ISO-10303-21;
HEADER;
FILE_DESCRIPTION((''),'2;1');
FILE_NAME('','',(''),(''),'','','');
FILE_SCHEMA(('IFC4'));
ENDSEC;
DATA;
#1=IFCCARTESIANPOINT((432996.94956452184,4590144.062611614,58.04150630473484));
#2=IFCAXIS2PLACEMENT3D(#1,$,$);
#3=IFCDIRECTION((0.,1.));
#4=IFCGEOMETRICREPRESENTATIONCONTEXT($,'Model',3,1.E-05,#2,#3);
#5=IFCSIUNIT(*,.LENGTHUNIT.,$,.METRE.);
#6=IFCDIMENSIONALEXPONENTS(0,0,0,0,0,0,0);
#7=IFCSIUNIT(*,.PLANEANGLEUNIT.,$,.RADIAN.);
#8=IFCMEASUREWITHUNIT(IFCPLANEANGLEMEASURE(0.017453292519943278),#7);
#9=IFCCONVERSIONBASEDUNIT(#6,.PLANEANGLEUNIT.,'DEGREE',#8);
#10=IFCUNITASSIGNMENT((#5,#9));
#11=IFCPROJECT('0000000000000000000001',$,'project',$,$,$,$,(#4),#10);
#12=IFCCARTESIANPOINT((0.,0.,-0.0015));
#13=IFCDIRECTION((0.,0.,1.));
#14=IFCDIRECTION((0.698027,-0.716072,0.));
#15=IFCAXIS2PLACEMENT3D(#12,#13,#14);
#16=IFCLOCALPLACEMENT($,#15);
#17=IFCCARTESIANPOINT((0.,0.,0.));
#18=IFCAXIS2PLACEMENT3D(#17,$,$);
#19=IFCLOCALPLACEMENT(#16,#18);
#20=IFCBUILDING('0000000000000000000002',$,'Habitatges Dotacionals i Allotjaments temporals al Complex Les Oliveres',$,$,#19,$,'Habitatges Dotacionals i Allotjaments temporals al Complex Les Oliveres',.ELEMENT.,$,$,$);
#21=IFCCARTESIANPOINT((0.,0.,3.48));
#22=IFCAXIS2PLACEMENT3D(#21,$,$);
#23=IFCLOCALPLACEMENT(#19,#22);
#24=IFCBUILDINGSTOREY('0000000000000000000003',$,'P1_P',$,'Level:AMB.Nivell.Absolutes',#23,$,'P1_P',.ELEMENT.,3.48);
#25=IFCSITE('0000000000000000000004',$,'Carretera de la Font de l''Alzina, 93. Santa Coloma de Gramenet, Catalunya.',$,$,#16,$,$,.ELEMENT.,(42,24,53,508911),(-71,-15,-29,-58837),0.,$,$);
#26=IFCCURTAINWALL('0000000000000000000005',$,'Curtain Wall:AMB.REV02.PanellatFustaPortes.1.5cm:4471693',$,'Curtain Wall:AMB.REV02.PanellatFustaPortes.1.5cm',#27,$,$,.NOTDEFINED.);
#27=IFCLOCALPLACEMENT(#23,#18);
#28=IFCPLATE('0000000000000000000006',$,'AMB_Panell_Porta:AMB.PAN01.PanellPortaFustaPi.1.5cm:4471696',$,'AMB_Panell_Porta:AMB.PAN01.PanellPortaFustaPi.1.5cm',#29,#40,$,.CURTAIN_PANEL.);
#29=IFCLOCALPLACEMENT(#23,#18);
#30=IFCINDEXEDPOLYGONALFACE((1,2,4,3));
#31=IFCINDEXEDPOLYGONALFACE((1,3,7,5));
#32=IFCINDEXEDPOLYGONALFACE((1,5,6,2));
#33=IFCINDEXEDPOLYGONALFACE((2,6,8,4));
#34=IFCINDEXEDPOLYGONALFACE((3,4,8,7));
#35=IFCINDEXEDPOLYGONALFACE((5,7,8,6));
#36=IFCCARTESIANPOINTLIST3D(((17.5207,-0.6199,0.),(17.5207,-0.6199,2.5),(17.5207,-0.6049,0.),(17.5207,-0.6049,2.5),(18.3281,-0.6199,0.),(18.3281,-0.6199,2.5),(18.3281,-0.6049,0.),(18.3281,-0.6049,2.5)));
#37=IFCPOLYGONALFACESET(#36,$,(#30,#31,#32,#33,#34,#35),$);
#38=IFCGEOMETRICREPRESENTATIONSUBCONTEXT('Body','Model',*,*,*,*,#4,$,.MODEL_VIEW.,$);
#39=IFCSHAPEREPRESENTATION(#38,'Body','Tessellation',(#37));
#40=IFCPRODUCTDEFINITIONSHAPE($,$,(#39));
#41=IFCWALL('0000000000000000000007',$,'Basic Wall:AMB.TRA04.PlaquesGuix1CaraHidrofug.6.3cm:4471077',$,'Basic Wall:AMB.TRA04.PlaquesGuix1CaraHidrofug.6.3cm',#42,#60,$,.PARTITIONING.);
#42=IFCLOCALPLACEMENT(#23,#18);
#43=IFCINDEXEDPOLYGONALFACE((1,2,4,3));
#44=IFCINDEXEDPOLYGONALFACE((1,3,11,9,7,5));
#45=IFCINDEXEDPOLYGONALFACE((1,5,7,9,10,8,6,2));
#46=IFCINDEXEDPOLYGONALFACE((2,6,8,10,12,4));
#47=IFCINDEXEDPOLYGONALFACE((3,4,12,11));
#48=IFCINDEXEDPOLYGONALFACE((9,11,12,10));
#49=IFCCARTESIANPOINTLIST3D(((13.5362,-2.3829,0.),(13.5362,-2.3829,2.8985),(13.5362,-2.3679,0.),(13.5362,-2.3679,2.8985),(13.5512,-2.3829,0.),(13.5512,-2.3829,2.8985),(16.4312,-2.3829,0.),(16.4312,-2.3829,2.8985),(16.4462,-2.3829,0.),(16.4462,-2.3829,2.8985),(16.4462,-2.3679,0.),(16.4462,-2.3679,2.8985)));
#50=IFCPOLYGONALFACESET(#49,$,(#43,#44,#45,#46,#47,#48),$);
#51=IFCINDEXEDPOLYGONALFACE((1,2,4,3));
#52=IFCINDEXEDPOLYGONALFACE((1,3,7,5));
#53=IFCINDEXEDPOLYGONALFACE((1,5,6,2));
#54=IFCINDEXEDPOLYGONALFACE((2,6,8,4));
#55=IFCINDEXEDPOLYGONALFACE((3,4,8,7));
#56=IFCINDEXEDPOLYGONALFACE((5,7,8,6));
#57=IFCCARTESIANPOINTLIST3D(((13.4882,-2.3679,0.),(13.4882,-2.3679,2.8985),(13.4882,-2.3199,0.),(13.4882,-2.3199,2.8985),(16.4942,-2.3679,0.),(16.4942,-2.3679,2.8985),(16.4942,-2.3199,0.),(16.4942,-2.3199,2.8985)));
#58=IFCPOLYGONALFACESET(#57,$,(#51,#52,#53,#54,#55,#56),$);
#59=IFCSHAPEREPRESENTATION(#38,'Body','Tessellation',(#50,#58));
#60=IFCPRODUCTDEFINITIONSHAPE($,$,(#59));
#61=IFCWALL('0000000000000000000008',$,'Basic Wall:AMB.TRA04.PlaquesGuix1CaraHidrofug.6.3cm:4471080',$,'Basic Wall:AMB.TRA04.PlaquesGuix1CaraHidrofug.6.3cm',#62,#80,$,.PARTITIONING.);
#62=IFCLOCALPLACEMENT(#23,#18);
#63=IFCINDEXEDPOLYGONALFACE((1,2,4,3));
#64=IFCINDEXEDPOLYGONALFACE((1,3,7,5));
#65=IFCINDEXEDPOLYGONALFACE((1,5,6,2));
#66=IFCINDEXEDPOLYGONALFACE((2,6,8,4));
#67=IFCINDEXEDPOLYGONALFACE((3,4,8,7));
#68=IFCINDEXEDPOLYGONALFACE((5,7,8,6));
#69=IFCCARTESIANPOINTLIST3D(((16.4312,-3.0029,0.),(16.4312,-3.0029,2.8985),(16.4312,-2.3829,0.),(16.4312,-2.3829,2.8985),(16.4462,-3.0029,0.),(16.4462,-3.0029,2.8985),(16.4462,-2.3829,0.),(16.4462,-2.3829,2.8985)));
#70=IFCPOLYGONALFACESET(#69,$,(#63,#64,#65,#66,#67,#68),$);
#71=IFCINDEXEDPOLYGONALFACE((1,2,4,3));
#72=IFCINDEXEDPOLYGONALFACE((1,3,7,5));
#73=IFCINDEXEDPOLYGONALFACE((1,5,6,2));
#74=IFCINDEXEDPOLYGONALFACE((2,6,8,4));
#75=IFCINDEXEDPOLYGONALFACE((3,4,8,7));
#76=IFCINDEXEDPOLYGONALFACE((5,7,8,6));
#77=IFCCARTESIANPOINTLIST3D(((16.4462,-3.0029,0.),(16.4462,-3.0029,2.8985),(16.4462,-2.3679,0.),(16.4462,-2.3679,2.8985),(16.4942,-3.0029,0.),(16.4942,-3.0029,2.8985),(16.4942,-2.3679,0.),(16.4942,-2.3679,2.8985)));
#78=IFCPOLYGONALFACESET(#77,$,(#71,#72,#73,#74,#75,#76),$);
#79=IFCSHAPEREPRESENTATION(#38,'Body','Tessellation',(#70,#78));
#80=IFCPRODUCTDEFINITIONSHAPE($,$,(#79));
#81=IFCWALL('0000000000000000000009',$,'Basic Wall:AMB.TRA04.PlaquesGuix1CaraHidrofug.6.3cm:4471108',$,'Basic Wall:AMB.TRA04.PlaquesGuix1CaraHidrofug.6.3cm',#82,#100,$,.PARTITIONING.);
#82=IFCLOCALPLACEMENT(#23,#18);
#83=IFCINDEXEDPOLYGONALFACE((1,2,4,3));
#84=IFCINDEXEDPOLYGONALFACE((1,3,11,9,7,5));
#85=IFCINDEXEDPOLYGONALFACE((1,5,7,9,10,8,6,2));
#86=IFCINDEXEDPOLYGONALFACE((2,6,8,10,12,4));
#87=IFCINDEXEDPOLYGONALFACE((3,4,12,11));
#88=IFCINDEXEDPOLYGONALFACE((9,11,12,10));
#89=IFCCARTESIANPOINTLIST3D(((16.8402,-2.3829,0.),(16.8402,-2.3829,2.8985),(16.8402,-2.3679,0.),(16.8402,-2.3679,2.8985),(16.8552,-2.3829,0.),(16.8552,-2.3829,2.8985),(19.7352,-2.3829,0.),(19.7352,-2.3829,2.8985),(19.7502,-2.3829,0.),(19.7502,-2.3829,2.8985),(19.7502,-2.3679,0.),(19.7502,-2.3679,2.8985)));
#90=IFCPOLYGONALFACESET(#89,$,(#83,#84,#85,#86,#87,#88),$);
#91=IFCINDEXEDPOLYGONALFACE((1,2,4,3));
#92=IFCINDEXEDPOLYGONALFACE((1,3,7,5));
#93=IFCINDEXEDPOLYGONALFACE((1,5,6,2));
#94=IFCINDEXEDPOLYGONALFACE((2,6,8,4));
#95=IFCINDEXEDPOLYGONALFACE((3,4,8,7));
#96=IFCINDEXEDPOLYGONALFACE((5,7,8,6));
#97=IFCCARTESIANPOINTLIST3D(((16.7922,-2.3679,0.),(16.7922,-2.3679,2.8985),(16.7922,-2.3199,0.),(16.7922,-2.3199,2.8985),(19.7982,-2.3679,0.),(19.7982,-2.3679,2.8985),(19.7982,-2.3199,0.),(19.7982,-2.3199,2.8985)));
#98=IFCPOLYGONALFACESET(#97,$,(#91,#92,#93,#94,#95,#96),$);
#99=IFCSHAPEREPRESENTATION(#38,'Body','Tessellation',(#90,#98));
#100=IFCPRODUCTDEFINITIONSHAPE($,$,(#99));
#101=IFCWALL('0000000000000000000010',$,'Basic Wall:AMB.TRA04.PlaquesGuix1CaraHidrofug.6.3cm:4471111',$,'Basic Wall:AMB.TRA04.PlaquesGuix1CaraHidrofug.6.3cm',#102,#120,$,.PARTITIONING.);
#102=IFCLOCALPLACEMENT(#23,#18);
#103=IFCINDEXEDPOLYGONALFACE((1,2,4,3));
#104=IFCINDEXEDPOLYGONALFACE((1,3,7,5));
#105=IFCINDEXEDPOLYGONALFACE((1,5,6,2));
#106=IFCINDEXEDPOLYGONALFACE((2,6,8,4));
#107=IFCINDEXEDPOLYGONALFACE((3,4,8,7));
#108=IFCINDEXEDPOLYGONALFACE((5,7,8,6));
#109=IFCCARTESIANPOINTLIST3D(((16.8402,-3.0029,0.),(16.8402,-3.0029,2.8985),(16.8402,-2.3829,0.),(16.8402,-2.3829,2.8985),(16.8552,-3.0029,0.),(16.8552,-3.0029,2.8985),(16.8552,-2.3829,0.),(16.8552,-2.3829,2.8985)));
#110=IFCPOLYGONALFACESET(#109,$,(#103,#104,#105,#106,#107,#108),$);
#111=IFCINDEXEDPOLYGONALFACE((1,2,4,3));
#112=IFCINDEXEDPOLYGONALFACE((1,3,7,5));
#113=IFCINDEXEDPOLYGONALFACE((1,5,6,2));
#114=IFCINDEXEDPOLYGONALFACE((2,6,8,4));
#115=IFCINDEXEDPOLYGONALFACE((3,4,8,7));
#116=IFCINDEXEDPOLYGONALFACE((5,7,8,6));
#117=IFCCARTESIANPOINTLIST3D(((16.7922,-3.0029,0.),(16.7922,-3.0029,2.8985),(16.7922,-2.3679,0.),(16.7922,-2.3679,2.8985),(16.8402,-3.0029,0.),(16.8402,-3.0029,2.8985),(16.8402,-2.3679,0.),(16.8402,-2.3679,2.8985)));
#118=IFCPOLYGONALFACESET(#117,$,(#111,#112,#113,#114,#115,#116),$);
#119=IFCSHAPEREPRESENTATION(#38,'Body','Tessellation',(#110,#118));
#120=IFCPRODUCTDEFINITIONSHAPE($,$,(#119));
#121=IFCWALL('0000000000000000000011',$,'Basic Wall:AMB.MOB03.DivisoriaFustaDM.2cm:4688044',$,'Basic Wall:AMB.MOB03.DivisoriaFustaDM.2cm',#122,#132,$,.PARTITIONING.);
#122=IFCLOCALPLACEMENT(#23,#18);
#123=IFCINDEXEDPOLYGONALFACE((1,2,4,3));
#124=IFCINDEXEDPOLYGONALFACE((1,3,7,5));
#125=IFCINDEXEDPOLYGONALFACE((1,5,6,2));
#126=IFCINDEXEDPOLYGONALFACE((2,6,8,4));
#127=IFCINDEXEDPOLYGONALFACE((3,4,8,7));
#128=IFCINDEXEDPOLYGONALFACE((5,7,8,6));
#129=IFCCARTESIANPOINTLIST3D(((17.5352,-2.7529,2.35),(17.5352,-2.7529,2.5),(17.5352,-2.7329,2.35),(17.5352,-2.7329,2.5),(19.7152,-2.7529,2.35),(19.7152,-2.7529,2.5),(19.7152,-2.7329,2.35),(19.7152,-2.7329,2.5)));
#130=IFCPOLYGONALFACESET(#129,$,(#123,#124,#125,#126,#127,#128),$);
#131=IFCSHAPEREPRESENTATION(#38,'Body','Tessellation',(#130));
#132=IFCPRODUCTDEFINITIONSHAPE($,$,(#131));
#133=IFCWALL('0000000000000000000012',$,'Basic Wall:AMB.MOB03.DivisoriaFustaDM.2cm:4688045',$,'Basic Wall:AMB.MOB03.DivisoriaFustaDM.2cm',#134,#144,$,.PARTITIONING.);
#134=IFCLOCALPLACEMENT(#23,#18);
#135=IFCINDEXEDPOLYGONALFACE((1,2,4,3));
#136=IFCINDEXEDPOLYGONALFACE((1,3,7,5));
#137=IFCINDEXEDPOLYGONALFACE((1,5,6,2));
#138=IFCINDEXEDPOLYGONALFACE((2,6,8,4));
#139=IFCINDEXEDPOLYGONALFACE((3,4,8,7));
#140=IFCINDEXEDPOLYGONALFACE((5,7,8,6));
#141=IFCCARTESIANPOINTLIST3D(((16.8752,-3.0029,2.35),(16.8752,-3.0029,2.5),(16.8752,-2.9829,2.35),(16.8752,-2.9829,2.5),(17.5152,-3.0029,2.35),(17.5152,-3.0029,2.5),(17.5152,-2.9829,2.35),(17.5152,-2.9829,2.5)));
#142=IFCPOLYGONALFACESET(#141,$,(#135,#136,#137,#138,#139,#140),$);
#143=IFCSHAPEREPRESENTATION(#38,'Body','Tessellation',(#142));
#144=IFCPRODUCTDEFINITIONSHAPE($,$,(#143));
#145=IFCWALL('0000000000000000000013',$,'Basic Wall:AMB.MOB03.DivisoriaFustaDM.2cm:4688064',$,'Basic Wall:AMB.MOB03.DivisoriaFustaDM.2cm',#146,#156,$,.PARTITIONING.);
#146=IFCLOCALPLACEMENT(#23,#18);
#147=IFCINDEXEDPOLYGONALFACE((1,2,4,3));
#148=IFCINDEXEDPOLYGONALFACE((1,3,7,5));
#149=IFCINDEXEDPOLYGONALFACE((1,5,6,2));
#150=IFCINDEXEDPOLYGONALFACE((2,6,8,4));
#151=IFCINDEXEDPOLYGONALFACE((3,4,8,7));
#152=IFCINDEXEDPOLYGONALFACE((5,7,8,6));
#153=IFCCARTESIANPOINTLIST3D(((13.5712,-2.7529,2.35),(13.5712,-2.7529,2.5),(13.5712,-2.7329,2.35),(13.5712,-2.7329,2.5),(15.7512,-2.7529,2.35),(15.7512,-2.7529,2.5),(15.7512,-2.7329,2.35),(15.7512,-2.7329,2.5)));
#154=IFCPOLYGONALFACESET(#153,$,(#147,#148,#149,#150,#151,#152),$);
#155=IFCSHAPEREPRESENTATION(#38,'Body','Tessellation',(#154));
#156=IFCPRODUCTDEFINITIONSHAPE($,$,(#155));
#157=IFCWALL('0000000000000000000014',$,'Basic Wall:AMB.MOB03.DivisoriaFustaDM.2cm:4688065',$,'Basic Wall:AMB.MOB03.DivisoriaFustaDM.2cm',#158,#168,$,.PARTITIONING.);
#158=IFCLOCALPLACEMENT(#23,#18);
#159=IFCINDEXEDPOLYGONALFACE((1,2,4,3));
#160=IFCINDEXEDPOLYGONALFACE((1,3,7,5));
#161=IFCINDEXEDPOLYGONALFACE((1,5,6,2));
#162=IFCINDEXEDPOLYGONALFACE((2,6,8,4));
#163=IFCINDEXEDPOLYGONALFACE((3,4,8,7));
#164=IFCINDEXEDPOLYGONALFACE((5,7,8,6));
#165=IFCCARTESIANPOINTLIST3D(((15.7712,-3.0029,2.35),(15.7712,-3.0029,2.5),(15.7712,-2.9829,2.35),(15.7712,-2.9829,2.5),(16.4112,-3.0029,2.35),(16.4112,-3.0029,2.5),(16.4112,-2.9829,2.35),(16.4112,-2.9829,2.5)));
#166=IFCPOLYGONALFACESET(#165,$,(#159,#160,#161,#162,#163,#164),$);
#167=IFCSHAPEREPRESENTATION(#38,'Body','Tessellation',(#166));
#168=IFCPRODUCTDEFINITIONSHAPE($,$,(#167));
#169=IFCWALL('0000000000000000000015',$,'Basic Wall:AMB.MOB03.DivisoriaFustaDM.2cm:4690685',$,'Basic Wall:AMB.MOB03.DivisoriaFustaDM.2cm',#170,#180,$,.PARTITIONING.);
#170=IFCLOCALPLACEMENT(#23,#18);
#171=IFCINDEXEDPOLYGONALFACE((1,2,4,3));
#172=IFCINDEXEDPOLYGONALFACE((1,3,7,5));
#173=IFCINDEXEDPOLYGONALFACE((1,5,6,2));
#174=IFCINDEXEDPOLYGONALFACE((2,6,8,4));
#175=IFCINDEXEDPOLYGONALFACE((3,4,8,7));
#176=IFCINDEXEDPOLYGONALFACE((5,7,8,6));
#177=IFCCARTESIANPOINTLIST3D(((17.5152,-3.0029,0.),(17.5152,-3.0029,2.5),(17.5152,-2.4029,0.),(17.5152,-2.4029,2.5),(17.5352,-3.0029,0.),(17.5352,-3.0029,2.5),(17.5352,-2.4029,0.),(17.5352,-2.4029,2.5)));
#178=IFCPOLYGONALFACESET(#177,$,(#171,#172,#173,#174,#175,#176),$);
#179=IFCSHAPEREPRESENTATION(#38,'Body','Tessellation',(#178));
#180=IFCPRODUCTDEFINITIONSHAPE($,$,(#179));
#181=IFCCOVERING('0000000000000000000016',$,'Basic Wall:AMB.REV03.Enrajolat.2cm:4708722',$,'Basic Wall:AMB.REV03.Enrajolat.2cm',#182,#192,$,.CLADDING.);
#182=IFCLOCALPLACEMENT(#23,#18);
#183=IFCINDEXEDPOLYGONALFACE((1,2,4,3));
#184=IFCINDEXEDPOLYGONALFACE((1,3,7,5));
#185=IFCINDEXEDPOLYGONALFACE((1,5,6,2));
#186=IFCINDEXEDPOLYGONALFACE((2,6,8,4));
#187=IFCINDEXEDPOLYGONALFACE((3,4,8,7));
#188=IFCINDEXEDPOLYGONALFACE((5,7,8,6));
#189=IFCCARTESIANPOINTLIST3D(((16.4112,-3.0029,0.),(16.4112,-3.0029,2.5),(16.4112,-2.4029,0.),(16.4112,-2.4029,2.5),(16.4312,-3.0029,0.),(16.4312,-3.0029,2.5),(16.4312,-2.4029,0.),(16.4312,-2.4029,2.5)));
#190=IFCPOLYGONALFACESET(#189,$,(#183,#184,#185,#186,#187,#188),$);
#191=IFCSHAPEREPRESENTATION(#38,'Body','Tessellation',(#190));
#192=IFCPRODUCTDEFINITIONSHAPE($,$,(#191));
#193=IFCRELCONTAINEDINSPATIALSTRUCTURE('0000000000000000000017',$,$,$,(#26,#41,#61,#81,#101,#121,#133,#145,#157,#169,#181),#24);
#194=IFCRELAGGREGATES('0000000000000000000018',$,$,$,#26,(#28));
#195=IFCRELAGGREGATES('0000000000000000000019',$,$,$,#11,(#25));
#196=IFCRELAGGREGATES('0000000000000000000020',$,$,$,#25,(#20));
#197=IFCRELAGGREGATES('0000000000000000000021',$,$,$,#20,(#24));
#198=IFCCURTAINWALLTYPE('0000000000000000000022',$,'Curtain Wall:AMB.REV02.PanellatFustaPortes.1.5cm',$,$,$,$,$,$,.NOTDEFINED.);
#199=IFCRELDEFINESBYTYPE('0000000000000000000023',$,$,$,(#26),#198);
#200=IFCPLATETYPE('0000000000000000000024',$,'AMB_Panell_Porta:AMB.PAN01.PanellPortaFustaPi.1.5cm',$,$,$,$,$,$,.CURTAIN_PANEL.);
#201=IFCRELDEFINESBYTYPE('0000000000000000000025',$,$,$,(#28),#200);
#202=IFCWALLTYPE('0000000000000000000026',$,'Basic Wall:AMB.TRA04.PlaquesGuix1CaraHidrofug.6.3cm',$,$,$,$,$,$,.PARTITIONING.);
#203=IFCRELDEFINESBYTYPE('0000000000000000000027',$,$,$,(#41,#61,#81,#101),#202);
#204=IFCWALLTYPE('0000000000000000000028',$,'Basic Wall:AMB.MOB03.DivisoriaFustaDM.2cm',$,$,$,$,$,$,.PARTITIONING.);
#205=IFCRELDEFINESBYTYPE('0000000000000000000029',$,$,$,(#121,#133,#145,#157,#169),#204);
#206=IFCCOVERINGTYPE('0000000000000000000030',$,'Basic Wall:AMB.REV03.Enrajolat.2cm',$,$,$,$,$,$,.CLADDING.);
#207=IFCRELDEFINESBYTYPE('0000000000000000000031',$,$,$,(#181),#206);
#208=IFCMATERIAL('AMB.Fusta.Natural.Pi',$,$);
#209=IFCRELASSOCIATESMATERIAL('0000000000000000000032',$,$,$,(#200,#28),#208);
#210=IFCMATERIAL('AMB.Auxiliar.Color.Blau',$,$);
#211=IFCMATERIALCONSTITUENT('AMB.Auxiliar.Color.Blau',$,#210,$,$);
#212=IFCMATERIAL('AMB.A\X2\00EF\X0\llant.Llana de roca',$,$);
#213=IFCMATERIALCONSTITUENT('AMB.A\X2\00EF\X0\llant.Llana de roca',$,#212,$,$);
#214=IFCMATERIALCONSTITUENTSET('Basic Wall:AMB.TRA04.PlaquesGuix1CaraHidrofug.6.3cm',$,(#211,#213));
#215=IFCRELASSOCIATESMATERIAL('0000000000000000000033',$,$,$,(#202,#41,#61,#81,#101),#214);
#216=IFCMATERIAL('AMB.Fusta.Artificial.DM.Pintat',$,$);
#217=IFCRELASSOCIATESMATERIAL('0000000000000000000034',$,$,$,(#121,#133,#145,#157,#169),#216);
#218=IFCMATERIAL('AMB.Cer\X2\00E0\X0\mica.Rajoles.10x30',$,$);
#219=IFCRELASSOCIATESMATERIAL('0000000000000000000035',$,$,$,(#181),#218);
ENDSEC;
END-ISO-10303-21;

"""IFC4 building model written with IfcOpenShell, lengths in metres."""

from ifc_helpers import new_model, entity, si_unit, converted_unit, direction, frame, origin, place, context, subcontext, project, spatial, indexed_curve, outline, extrude, source, transform, mapped, material, constituent, constituent_set, type_object, type_shapes, element, aggregate, save


model = new_model("IFC4")

# Units and contexts
model_context = context("Model", 3, precision=1e-05, world=frame((432996.94956452184, 4590144.062611614, 58.04150630473484)), true_north=direction((0.0, 1.0)))
body_context = subcontext(model_context, "Body", "Model", "MODEL_VIEW")
ifc_project = project(units=[si_unit("LENGTHUNIT", "METRE"), converted_unit("PLANEANGLEUNIT", "DEGREE", entity("IfcPlaneAngleMeasure", 0.017453292519943278), si_unit("PLANEANGLEUNIT", "RADIAN"), dimensions=[0, 0, 0, 0, 0, 0, 0])], contexts=[model_context])

# Site, building, storey
site_placement = place(None, frame((0.0, 0.0, -0.0015), z_axis=(0.0, 0.0, 1.0), x_axis=(0.698027, -0.716072, 0.0)))
site = spatial("IfcSite", under=ifc_project, at=site_placement, Name="Carretera de la Font de l'Alzina, 93. Santa Coloma de Gramenet, Catalunya.", CompositionType="ELEMENT", RefLatitude=(42, 24, 53, 508911), RefLongitude=(-71, -15, -29, -58837), RefElevation=0.0)
building_placement = place(site_placement, origin())
building = spatial("IfcBuilding", under=site, at=building_placement, Name="Habitatges Dotacionals i Allotjaments temporals al Complex Les Oliveres", LongName="Habitatges Dotacionals i Allotjaments temporals al Complex Les Oliveres", CompositionType="ELEMENT")
storey_placement = place(building_placement, frame((0.0, 0.0, 3.48)))
storey = spatial("IfcBuildingStorey", under=building, at=storey_placement, Name="P1_P", ObjectType="Level:AMB.Nivell.Absolutes", LongName="P1_P", CompositionType="ELEMENT", Elevation=3.48)

# Curtain wall, plate
curtain_wall_type = type_object("IfcCurtainWallType", Name="Curtain Wall:AMB.REV02.PanellatFustaPortes.1.5cm", PredefinedType="NOTDEFINED")
curtain_wall_placement = place(storey_placement, frame((0.0, 0.0, -3.48)))
curtain_wall = element("IfcCurtainWall", 1, at=curtain_wall_placement, inside=storey, type_object=curtain_wall_type, Name="Curtain Wall:AMB.REV02.PanellatFustaPortes.1.5cm:4471693", ObjectType="Curtain Wall:AMB.REV02.PanellatFustaPortes.1.5cm", PredefinedType="NOTDEFINED")
ifc_material_1 = material(Name="AMB.Fusta.Natural.Pi")
plate_type = type_object("IfcPlateType", Name="AMB_Panell_Porta:AMB.PAN01.PanellPortaFustaPi.1.5cm", PredefinedType="CURTAIN_PANEL", material=ifc_material_1)
shared_shape_1 = source(origin(), body_context, "Body", "SweptSolid", [
    extrude(outline(indexed_curve([(-0.0075, -0.4037), (0.0075, -0.4037), (0.0075, 0.4037), (-0.0075, 0.4037), (-0.0075, -0.4037)], self_intersect=False)), frame((0.0, 0.0, 0.0), z_axis=(0.0, 0.0, 1.0), x_axis=(0.0, 1.0, 0.0)), (0.0, 0.0, 1.0), 2.5),
])
type_shapes(plate_type, [shared_shape_1])
plate_placement = place(curtain_wall_placement, frame((17.9244, -0.6124, 3.48)))
plate = element("IfcPlate", 2, at=plate_placement, type_object=plate_type, material=ifc_material_1, Name="AMB_Panell_Porta:AMB.PAN01.PanellPortaFustaPi.1.5cm:4471696", ObjectType="AMB_Panell_Porta:AMB.PAN01.PanellPortaFustaPi.1.5cm", PredefinedType="CURTAIN_PANEL", context=body_context, shape_type="MappedRepresentation", body=[
    mapped(shared_shape_1, transform((0.0, 0.0, 0.0), scale=1.0)),
])
aggregate(curtain_wall, [plate])

# Walls
ifc_material_2 = material(Name="AMB.Auxiliar.Color.Blau")
ifc_constituent_1 = constituent(ifc_material_2, Name="AMB.Auxiliar.Color.Blau")
ifc_material_3 = material(Name="AMB.Aïllant.Llana de roca")
ifc_constituent_2 = constituent(ifc_material_3, Name="AMB.Aïllant.Llana de roca")
ifc_constituent_set = constituent_set(constituents=[ifc_constituent_1, ifc_constituent_2], Name="Basic Wall:AMB.TRA04.PlaquesGuix1CaraHidrofug.6.3cm")
wall_type_1 = type_object("IfcWallType", Name="Basic Wall:AMB.TRA04.PlaquesGuix1CaraHidrofug.6.3cm", PredefinedType="PARTITIONING", material=ifc_constituent_set)
wall_1_placement = place(storey_placement, frame((16.4942, -2.3514, 0.0), z_axis=(0.0, 0.0, 1.0), x_axis=(-1.0, 0.0, 0.0)))
element("IfcWall", 3, at=wall_1_placement, inside=storey, type_object=wall_type_1, material=ifc_constituent_set, Name="Basic Wall:AMB.TRA04.PlaquesGuix1CaraHidrofug.6.3cm:4471077", ObjectType="Basic Wall:AMB.TRA04.PlaquesGuix1CaraHidrofug.6.3cm", PredefinedType="PARTITIONING", context=body_context, shape_type="SweptSolid", body=[
    extrude(outline(indexed_curve([(-1.44, -0.005), (1.44, -0.005), (1.455, -0.005), (1.455, 0.01), (-1.455, 0.01), (-1.455, -0.005), (-1.44, -0.005)], self_intersect=False)), frame((1.503, 0.0265, 0.0), z_axis=(0.0, 0.0, 1.0), x_axis=(-1.0, 0.0, 0.0)), (0.0, 0.0, 1.0), 2.8985),
    extrude(outline(indexed_curve([(-0.024, -1.503), (0.024, -1.503), (0.024, 1.503), (-0.024, 1.503), (-0.024, -1.503)], self_intersect=False)), frame((1.503, -0.0075, 0.0), z_axis=(0.0, 0.0, 1.0), x_axis=(0.0, 1.0, 0.0)), (0.0, 0.0, 1.0), 2.8985),
])
wall_2_placement = place(storey_placement, frame((16.4627, -3.0029, 0.0), z_axis=(0.0, 0.0, 1.0), x_axis=(0.0, 1.0, 0.0)))
element("IfcWall", 4, at=wall_2_placement, inside=storey, type_object=wall_type_1, material=ifc_constituent_set, Name="Basic Wall:AMB.TRA04.PlaquesGuix1CaraHidrofug.6.3cm:4471080", ObjectType="Basic Wall:AMB.TRA04.PlaquesGuix1CaraHidrofug.6.3cm", PredefinedType="PARTITIONING", context=body_context, shape_type="SweptSolid", body=[
    extrude(outline(indexed_curve([(-0.0075, -0.31), (0.0075, -0.31), (0.0075, 0.31), (-0.0075, 0.31), (-0.0075, -0.31)], self_intersect=False)), frame((0.31, 0.024, 0.0), z_axis=(0.0, 0.0, 1.0), x_axis=(0.0, -1.0, 0.0)), (0.0, 0.0, 1.0), 2.8985),
    extrude(outline(indexed_curve([(-0.024, -0.3175), (0.024, -0.3175), (0.024, 0.3175), (-0.024, 0.3175), (-0.024, -0.3175)], self_intersect=False)), frame((0.3175, -0.0075, 0.0), z_axis=(0.0, 0.0, 1.0), x_axis=(0.0, 1.0, 0.0)), (0.0, 0.0, 1.0), 2.8985),
])
wall_3_placement = place(storey_placement, frame((16.7922, -2.3514, 0.0)))
element("IfcWall", 5, at=wall_3_placement, inside=storey, type_object=wall_type_1, material=ifc_constituent_set, Name="Basic Wall:AMB.TRA04.PlaquesGuix1CaraHidrofug.6.3cm:4471108", ObjectType="Basic Wall:AMB.TRA04.PlaquesGuix1CaraHidrofug.6.3cm", PredefinedType="PARTITIONING", context=body_context, shape_type="SweptSolid", body=[
    extrude(outline(indexed_curve([(-1.44, -0.005), (1.44, -0.005), (1.455, -0.005), (1.455, 0.01), (-1.455, 0.01), (-1.455, -0.005), (-1.44, -0.005)], self_intersect=False)), frame((1.503, -0.0265, 0.0)), (0.0, 0.0, 1.0), 2.8985),
    extrude(outline(indexed_curve([(-0.024, -1.503), (0.024, -1.503), (0.024, 1.503), (-0.024, 1.503), (-0.024, -1.503)], self_intersect=False)), frame((1.503, 0.0075, 0.0), z_axis=(0.0, 0.0, 1.0), x_axis=(0.0, -1.0, 0.0)), (0.0, 0.0, 1.0), 2.8985),
])
wall_4_placement = place(storey_placement, frame((16.8237, -3.0029, 0.0), z_axis=(0.0, 0.0, 1.0), x_axis=(0.0, 1.0, 0.0)))
element("IfcWall", 6, at=wall_4_placement, inside=storey, type_object=wall_type_1, material=ifc_constituent_set, Name="Basic Wall:AMB.TRA04.PlaquesGuix1CaraHidrofug.6.3cm:4471111", ObjectType="Basic Wall:AMB.TRA04.PlaquesGuix1CaraHidrofug.6.3cm", PredefinedType="PARTITIONING", context=body_context, shape_type="SweptSolid", body=[
    extrude(outline(indexed_curve([(-0.0075, -0.31), (0.0075, -0.31), (0.0075, 0.31), (-0.0075, 0.31), (-0.0075, -0.31)], self_intersect=False)), frame((0.31, -0.024, 0.0), z_axis=(0.0, 0.0, 1.0), x_axis=(0.0, 1.0, 0.0)), (0.0, 0.0, 1.0), 2.8985),
    extrude(outline(indexed_curve([(-0.024, -0.3175), (0.024, -0.3175), (0.024, 0.3175), (-0.024, 0.3175), (-0.024, -0.3175)], self_intersect=False)), frame((0.3175, 0.0075, 0.0), z_axis=(0.0, 0.0, 1.0), x_axis=(0.0, -1.0, 0.0)), (0.0, 0.0, 1.0), 2.8985),
])
ifc_material_4 = material(Name="AMB.Fusta.Artificial.DM.Pintat")
wall_type_2 = type_object("IfcWallType", Name="Basic Wall:AMB.MOB03.DivisoriaFustaDM.2cm", PredefinedType="PARTITIONING")
wall_5_placement = place(storey_placement, frame((17.5352, -2.7429, 2.35)))
element("IfcWall", 7, at=wall_5_placement, inside=storey, type_object=wall_type_2, material=ifc_material_4, Name="Basic Wall:AMB.MOB03.DivisoriaFustaDM.2cm:4688044", ObjectType="Basic Wall:AMB.MOB03.DivisoriaFustaDM.2cm", PredefinedType="PARTITIONING", context=body_context, shape_type="SweptSolid", body=[
    extrude(outline(indexed_curve([(2.18, 0.01), (0.0, 0.01), (0.0, -0.01), (2.18, -0.01), (2.18, 0.01)], self_intersect=False)), origin(), (0.0, 0.0, 1.0), 0.15),
])
wall_6_placement = place(storey_placement, frame((17.5152, -2.9929, 2.35), z_axis=(0.0, 0.0, 1.0), x_axis=(-1.0, 0.0, 0.0)))
element("IfcWall", 8, at=wall_6_placement, inside=storey, type_object=wall_type_2, material=ifc_material_4, Name="Basic Wall:AMB.MOB03.DivisoriaFustaDM.2cm:4688045", ObjectType="Basic Wall:AMB.MOB03.DivisoriaFustaDM.2cm", PredefinedType="PARTITIONING", context=body_context, shape_type="SweptSolid", body=[
    extrude(outline(indexed_curve([(0.64, 0.01), (0.0, 0.01), (0.0, -0.01), (0.64, -0.01), (0.64, 0.01)], self_intersect=False)), origin(), (0.0, 0.0, 1.0), 0.15),
])
wall_7_placement = place(storey_placement, frame((15.7512, -2.7429, 2.35), z_axis=(0.0, 0.0, 1.0), x_axis=(-1.0, 0.0, 0.0)))
element("IfcWall", 9, at=wall_7_placement, inside=storey, type_object=wall_type_2, material=ifc_material_4, Name="Basic Wall:AMB.MOB03.DivisoriaFustaDM.2cm:4688064", ObjectType="Basic Wall:AMB.MOB03.DivisoriaFustaDM.2cm", PredefinedType="PARTITIONING", context=body_context, shape_type="SweptSolid", body=[
    extrude(outline(indexed_curve([(2.18, 0.01), (0.0, 0.01), (0.0, -0.01), (2.18, -0.01), (2.18, 0.01)], self_intersect=False)), origin(), (0.0, 0.0, 1.0), 0.15),
])
wall_8_placement = place(storey_placement, frame((15.7712, -2.9929, 2.35)))
element("IfcWall", 10, at=wall_8_placement, inside=storey, type_object=wall_type_2, material=ifc_material_4, Name="Basic Wall:AMB.MOB03.DivisoriaFustaDM.2cm:4688065", ObjectType="Basic Wall:AMB.MOB03.DivisoriaFustaDM.2cm", PredefinedType="PARTITIONING", context=body_context, shape_type="SweptSolid", body=[
    extrude(outline(indexed_curve([(0.64, 0.01), (0.0, 0.01), (0.0, -0.01), (0.64, -0.01), (0.64, 0.01)], self_intersect=False)), origin(), (0.0, 0.0, 1.0), 0.15),
])
wall_9_placement = place(storey_placement, frame((17.5252, -2.4029, 0.0), z_axis=(0.0, 0.0, 1.0), x_axis=(0.0, -1.0, 0.0)))
element("IfcWall", 11, at=wall_9_placement, inside=storey, type_object=wall_type_2, material=ifc_material_4, Name="Basic Wall:AMB.MOB03.DivisoriaFustaDM.2cm:4690685", ObjectType="Basic Wall:AMB.MOB03.DivisoriaFustaDM.2cm", PredefinedType="PARTITIONING", context=body_context, shape_type="SweptSolid", body=[
    extrude(outline(indexed_curve([(0.6, 0.01), (0.0, 0.01), (0.0, -0.01), (0.6, -0.01), (0.6, 0.01)], self_intersect=False)), origin(), (0.0, 0.0, 1.0), 2.5),
])

# Covering
ifc_material_5 = material(Name="AMB.Ceràmica.Rajoles.10x30")
covering_type = type_object("IfcCoveringType", Name="Basic Wall:AMB.REV03.Enrajolat.2cm", PredefinedType="CLADDING")
covering_1_placement = place(storey_placement, frame((16.4212, -2.4029, 0.0), z_axis=(0.0, 0.0, 1.0), x_axis=(0.0, -1.0, 0.0)))
element("IfcCovering", 12, at=covering_1_placement, inside=storey, type_object=covering_type, material=ifc_material_5, Name="Basic Wall:AMB.REV03.Enrajolat.2cm:4708722", ObjectType="Basic Wall:AMB.REV03.Enrajolat.2cm", PredefinedType="CLADDING", context=body_context, shape_type="SweptSolid", body=[
    extrude(outline(indexed_curve([(0.6, 0.01), (0.0, 0.01), (0.0, -0.01), (0.6, -0.01), (0.6, 0.01)], self_intersect=False)), origin(), (0.0, 0.0, 1.0), 2.5),
])

save(model, "model.ifc")
